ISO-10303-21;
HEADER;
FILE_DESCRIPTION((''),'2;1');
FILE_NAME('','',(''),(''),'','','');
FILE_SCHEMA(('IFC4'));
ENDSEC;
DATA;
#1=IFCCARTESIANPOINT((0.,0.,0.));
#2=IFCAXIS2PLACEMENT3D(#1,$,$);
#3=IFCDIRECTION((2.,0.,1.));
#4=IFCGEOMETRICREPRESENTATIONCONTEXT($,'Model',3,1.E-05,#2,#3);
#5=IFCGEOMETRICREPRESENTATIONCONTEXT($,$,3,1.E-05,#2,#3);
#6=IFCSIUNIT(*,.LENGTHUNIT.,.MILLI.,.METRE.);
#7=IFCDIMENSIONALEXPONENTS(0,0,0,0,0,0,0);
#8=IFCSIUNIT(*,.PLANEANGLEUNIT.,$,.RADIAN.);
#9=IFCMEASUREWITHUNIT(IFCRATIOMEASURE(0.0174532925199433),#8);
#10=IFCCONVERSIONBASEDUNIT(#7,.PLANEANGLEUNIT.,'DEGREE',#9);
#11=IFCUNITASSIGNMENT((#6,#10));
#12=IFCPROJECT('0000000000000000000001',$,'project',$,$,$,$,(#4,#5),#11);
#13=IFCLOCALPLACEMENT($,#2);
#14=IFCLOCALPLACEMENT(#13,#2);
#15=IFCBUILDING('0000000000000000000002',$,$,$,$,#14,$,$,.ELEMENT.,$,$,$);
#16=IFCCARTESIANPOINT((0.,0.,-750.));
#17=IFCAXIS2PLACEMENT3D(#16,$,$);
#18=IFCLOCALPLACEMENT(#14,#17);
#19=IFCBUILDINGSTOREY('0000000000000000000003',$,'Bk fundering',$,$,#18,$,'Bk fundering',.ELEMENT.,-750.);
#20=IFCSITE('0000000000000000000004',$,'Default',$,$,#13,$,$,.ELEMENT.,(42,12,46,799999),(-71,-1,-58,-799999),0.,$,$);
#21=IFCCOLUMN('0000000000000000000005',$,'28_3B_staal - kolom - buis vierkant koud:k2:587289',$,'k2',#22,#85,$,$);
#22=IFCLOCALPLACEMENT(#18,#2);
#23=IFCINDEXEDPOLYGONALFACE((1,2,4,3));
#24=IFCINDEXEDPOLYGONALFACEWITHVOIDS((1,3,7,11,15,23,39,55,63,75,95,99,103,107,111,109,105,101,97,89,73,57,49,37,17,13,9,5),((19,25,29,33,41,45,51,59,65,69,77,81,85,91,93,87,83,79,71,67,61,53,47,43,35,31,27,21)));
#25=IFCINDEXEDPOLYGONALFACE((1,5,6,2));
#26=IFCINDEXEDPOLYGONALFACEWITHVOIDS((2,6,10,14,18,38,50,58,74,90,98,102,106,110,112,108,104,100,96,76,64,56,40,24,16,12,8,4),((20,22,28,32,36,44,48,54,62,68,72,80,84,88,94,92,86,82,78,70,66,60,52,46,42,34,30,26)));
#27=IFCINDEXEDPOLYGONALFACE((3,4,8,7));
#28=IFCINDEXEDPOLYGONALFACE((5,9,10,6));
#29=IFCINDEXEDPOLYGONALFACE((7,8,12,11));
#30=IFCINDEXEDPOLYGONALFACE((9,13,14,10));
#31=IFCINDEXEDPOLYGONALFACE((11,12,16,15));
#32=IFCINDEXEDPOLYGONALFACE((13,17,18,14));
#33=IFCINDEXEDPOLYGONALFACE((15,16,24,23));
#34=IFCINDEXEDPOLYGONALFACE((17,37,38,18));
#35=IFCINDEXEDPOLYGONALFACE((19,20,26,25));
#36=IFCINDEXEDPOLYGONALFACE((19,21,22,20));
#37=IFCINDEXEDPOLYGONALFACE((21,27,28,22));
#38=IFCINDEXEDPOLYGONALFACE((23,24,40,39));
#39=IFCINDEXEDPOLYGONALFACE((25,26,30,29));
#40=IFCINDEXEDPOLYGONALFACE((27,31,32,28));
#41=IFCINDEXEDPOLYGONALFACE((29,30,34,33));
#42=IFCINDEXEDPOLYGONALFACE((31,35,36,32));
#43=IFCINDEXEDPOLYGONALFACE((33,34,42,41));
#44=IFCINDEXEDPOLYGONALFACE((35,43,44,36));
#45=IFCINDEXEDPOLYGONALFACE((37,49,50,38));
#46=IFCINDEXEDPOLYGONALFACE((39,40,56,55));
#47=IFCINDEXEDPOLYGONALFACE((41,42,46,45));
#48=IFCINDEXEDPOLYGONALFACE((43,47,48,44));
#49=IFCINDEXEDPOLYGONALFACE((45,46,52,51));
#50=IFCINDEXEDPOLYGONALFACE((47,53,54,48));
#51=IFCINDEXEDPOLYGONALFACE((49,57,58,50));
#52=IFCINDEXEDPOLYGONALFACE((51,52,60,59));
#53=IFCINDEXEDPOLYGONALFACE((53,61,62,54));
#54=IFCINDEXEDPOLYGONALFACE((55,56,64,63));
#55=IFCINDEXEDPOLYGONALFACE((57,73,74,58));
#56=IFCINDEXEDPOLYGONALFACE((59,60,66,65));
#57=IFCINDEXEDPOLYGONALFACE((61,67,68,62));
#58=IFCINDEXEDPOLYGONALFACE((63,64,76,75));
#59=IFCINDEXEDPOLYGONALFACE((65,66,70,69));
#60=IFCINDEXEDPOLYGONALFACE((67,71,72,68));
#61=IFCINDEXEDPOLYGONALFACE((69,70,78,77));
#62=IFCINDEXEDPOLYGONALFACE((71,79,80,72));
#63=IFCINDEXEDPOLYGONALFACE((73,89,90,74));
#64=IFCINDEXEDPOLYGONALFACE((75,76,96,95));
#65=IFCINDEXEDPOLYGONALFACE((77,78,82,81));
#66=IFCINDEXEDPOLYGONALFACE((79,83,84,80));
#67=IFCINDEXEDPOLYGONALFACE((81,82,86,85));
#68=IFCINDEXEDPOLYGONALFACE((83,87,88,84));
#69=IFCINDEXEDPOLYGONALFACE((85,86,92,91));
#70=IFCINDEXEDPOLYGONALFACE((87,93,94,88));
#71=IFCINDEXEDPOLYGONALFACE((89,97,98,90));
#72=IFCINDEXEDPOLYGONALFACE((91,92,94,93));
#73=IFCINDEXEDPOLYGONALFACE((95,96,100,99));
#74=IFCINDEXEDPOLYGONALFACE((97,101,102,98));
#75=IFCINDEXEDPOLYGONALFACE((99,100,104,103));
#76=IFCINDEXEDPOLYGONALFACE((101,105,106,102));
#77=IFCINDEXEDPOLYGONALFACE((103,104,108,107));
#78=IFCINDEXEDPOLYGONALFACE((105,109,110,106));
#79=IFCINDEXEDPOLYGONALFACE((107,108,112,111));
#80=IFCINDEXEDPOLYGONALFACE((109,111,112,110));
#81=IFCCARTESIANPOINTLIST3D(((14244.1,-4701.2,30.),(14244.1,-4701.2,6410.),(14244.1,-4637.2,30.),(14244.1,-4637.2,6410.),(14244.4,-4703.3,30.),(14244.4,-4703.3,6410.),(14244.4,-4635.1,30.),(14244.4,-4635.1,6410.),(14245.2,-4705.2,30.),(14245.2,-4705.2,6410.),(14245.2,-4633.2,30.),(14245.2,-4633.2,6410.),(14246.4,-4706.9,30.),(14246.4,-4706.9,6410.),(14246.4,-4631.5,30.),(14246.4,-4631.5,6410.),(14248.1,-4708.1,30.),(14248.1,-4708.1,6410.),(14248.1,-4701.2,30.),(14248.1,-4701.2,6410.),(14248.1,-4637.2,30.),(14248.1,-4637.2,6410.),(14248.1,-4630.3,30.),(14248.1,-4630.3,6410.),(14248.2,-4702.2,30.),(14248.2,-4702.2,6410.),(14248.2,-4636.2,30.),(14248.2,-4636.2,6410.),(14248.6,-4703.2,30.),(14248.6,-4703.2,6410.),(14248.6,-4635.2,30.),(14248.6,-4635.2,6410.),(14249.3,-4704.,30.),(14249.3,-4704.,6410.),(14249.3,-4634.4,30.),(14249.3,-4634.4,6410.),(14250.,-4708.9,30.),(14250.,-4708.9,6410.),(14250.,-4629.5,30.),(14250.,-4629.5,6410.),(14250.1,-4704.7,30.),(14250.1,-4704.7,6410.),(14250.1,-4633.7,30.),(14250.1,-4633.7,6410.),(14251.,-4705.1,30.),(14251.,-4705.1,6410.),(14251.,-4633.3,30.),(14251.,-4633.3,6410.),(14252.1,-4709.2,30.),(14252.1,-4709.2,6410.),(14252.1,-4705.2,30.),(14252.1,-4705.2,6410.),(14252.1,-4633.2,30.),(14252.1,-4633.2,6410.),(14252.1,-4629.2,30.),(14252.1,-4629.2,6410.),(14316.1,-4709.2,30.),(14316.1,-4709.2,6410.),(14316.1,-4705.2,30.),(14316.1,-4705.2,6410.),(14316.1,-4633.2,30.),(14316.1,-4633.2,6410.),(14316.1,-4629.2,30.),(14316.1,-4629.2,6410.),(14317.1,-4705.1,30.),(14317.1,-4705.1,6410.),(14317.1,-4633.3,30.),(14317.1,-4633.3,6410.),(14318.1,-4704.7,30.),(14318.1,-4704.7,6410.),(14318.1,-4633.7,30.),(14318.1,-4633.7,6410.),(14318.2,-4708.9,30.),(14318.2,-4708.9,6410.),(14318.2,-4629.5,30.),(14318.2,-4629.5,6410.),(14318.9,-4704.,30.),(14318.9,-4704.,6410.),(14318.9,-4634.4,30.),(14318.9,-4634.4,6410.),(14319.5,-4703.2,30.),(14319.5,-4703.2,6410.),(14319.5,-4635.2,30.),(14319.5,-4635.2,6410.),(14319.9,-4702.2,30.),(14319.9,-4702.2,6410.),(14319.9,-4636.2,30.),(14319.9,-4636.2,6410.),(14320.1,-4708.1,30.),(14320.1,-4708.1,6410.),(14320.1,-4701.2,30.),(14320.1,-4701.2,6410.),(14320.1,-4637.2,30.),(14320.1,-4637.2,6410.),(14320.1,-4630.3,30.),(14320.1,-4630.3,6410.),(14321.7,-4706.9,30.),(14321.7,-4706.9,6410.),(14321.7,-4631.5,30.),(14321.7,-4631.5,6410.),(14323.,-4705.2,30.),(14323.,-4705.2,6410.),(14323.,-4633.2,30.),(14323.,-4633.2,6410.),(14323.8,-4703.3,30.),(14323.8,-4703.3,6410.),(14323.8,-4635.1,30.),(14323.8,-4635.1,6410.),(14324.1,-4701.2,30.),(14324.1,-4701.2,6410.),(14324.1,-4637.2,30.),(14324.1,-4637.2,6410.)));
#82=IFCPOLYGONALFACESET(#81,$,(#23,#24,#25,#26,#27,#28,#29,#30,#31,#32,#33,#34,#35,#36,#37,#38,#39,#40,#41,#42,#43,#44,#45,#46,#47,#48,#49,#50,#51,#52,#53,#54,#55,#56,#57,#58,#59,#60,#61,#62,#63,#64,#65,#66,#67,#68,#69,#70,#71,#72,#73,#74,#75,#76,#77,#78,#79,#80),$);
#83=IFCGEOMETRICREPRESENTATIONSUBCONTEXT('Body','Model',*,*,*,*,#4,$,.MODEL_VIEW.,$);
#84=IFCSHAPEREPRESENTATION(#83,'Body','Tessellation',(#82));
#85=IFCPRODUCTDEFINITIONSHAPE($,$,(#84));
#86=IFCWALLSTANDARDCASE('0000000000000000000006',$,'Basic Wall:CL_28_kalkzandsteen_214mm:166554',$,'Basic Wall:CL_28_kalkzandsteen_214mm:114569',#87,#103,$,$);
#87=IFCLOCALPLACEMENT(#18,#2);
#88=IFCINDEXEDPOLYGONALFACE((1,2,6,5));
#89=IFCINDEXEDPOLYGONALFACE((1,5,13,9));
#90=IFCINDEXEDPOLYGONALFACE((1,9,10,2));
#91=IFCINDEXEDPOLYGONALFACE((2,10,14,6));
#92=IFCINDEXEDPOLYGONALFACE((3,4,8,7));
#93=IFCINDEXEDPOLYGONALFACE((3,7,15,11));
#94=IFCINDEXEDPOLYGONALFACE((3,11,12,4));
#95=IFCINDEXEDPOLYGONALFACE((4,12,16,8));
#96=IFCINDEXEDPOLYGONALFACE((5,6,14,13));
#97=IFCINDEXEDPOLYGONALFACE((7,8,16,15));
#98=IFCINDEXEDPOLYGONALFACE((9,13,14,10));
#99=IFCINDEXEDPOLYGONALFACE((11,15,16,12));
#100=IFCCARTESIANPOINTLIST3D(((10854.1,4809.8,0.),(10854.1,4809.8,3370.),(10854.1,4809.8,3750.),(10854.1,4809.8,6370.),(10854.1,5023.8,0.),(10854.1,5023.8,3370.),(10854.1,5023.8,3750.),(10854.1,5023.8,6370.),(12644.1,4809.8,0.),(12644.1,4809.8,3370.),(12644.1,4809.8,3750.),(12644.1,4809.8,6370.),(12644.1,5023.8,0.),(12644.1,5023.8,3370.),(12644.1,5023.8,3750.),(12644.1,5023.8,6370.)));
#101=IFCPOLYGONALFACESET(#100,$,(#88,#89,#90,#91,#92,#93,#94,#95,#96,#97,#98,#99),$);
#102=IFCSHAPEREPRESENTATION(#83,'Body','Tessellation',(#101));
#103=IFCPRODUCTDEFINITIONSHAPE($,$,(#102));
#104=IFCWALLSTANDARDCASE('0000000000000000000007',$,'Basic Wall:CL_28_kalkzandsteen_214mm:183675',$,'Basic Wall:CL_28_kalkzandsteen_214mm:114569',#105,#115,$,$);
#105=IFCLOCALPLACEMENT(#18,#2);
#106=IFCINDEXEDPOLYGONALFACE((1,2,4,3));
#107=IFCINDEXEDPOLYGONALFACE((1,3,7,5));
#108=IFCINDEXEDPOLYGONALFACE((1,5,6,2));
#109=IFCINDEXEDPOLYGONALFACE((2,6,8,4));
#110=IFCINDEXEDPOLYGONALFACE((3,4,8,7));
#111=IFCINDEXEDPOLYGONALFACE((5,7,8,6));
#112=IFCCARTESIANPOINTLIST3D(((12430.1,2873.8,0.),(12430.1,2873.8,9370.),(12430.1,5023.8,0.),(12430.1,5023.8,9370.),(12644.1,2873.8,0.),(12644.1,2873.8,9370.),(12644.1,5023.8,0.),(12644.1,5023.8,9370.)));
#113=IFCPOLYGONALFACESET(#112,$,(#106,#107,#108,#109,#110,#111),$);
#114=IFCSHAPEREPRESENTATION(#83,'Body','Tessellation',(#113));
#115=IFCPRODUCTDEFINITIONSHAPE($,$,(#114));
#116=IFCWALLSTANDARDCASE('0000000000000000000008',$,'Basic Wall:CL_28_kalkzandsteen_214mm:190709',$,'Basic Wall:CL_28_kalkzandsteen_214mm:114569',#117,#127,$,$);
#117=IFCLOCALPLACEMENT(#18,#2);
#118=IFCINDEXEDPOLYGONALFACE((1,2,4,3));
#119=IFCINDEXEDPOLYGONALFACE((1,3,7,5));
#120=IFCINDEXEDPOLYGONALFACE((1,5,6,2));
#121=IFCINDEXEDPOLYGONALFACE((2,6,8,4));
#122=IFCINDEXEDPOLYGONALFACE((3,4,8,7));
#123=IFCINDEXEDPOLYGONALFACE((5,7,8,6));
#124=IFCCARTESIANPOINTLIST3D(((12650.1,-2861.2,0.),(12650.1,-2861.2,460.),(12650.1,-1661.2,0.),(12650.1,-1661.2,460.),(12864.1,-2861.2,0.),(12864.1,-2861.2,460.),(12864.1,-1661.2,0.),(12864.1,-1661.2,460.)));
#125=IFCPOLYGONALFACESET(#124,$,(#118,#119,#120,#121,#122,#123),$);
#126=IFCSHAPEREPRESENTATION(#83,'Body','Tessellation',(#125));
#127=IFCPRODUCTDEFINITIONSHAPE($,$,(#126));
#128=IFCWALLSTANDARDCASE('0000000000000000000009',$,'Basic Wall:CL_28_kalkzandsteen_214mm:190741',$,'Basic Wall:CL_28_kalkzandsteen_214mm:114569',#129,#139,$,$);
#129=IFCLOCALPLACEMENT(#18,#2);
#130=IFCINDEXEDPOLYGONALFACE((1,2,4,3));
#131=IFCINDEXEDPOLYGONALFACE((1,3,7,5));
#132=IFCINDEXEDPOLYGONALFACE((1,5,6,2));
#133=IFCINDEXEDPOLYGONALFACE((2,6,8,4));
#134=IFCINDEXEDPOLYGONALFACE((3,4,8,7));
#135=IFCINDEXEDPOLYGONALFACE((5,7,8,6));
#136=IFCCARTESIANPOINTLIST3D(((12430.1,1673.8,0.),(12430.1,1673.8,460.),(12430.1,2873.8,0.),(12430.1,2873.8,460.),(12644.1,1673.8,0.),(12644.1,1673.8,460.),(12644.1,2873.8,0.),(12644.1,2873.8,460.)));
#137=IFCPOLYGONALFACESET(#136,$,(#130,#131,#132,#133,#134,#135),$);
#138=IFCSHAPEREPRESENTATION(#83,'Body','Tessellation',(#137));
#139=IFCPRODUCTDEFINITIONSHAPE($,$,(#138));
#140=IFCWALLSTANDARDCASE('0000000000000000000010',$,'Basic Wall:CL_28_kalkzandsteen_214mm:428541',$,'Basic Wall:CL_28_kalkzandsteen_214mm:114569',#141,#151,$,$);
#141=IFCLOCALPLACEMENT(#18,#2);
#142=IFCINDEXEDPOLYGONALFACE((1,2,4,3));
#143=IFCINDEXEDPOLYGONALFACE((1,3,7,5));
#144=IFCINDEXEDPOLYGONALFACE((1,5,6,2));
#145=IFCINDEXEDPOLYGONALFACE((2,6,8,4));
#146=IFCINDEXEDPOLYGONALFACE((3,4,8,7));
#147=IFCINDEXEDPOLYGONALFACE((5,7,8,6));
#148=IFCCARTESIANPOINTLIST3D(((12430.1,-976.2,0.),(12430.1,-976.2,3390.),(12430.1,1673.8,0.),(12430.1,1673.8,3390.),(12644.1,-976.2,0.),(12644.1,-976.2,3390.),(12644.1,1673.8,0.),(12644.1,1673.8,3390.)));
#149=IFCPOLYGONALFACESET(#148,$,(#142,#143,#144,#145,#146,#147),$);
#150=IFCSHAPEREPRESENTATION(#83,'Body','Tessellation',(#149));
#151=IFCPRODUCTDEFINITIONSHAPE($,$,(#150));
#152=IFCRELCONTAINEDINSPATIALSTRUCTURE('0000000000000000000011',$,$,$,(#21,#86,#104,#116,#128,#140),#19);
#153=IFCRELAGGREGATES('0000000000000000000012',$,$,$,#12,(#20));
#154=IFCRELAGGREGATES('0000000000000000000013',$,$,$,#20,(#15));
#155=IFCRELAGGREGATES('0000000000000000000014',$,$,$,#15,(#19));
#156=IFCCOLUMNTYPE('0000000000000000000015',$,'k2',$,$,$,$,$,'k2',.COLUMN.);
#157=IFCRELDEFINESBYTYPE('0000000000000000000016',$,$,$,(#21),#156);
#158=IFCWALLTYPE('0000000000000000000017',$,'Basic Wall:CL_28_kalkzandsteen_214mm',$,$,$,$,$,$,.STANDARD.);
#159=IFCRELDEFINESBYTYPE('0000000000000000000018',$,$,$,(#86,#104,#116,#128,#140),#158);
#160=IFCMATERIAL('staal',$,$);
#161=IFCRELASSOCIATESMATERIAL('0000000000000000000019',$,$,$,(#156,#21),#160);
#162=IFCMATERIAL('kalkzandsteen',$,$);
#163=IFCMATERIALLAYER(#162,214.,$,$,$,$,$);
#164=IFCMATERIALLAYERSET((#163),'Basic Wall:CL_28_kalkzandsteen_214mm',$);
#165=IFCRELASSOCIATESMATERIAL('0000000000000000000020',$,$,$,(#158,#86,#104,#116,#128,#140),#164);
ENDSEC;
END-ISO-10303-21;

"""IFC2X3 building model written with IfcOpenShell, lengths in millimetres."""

from ifc_helpers import new_model, entity, si_unit, converted_unit, direction, frame, frame_2d, origin, place, context, subcontext, project, spatial, polyline, circle_curve, parameter, trimmed, segment, composite_curve, rectangle, outline, extrude, clip, bounded_halfspace, source, transform, mapped, material, layer, layer_set, layer_usage, type_object, type_shapes, element, save


model = new_model("IFC2X3")

# Units and contexts
model_context = context("Model", 3, precision=1e-05, world=origin(), true_north=direction((2.0, 0.0, 1.0)))
context_of_model = context(None, 3, precision=1e-05, world=origin(), true_north=direction((2.0, 0.0, 1.0)))
body_context = subcontext(model_context, "Body", "Model", "MODEL_VIEW")
ifc_project = project(units=[si_unit("LENGTHUNIT", "METRE", prefix="MILLI"), converted_unit("PLANEANGLEUNIT", "DEGREE", entity("IfcRatioMeasure", 0.0174532925199433), si_unit("PLANEANGLEUNIT", "RADIAN"), dimensions=[0, 0, 0, 0, 0, 0, 0])], contexts=[model_context, context_of_model])

# Site, building, storey
site_placement = place(None, origin())
site = spatial("IfcSite", under=ifc_project, at=site_placement, Name="Default", CompositionType="ELEMENT", RefLatitude=(42, 12, 46, 799999), RefLongitude=(-71, -1, -58, -799999), RefElevation=0.0)
building_placement = place(site_placement, origin())
building = spatial("IfcBuilding", under=site, at=building_placement, CompositionType="ELEMENT")
storey_placement = place(building_placement, frame((0.0, 0.0, -750.0)))
storey = spatial("IfcBuildingStorey", under=building, at=storey_placement, Name="Bk fundering", LongName="Bk fundering", CompositionType="ELEMENT", Elevation=-750.0)

# Column
ifc_material_1 = material(Name="staal")
column_type = type_object("IfcColumnType", Name="k2", ElementType="k2", PredefinedType="COLUMN", material=ifc_material_1)
shared_shape = source(origin(), body_context, "Body", "SweptSolid", [
    extrude(outline(composite_curve([segment(polyline([(-32.0, -40.0), (32.0, -40.0)]), True, "CONTINUOUS"), segment(trimmed(circle_curve(frame_2d((32.0, -32.0), x_axis=(-1.0, 0.0)), 8.0), [parameter(90.0)], [parameter(180.0)], True, "PARAMETER"), True, "CONTINUOUS"), segment(polyline([(40.0, -32.0), (40.0, 32.0)]), True, "CONTINUOUS"), segment(trimmed(circle_curve(frame_2d((32.0, 32.0), x_axis=(-1.0, 0.0)), 8.0), [parameter(180.0)], [parameter(270.0)], True, "PARAMETER"), True, "CONTINUOUS"), segment(polyline([(32.0, 40.0), (-32.0, 40.0)]), True, "CONTINUOUS"), segment(trimmed(circle_curve(frame_2d((-32.0, 32.0), x_axis=(-1.0, 0.0)), 8.0), [parameter(270.0)], [parameter(360.0)], True, "PARAMETER"), True, "CONTINUOUS"), segment(polyline([(-40.0, 32.0), (-40.0, -32.0)]), True, "CONTINUOUS"), segment(trimmed(circle_curve(frame_2d((-32.0, -32.0), x_axis=(-1.0, 0.0)), 8.0), [parameter(360.0)], [parameter(90.0)], True, "PARAMETER"), True, "CONTINUOUS")], self_intersect=False), holes=[composite_curve([segment(trimmed(circle_curve(frame_2d((-32.0, -32.0), x_axis=(-1.0, 0.0)), 4.0), [parameter(0.0)], [parameter(90.0)], True, "PARAMETER"), False, "CONTINUOUS"), segment(polyline([(-36.0, -32.0), (-36.0, 32.0)]), True, "CONTINUOUS"), segment(trimmed(circle_curve(frame_2d((-32.0, 32.0), x_axis=(-1.0, 0.0)), 4.0), [parameter(270.0)], [parameter(0.0)], True, "PARAMETER"), False, "CONTINUOUS"), segment(polyline([(-32.0, 36.0), (32.0, 36.0)]), True, "CONTINUOUS"), segment(trimmed(circle_curve(frame_2d((32.0, 32.0), x_axis=(-1.0, 0.0)), 4.0), [parameter(180.0)], [parameter(270.0)], True, "PARAMETER"), False, "CONTINUOUS"), segment(polyline([(36.0, 32.0), (36.0, -32.0)]), True, "CONTINUOUS"), segment(trimmed(circle_curve(frame_2d((32.0, -32.0), x_axis=(-1.0, 0.0)), 4.0), [parameter(90.0)], [parameter(180.0)], True, "PARAMETER"), False, "CONTINUOUS"), segment(polyline([(32.0, -36.0), (-32.0, -36.0)]), True, "CONTINUOUS")], self_intersect=False)]), frame((14284.1, -4669.2, -720.0)), (0.0, 0.0, 1.0), 6380.0),
])
type_shapes(column_type, [shared_shape])
column_placement = place(storey_placement, frame((0.0, 0.0, 750.0)))
element("IfcColumn", 1, at=column_placement, inside=storey, type_object=column_type, material=ifc_material_1, Name="28_3B_staal - kolom - buis vierkant koud:k2:587289", ObjectType="k2", context=body_context, shape_type="MappedRepresentation", body=[
    mapped(shared_shape, transform((0.0, 0.0, 0.0), scale=1.0)),
])

# Wall, opening
ifc_material_2 = material(Name="kalkzandsteen")
ifc_layer_1 = layer(ifc_material_2, 214.0)
ifc_layer_set_1 = layer_set([ifc_layer_1], Name="Basic Wall:CL_28_kalkzandsteen_214mm")
ifc_layer_usage_1 = layer_usage(ifc_layer_set_1, "AXIS2", "NEGATIVE", 107.0)
wall_type_1 = type_object("IfcWallType", Name="Basic Wall:CL_28_kalkzandsteen_214mm", PredefinedType="STANDARD", material=ifc_layer_set_1)
wall_1_placement = place(storey_placement, frame((12644.1, 4916.8, 0.0), z_axis=(0.0, 0.0, 1.0), x_axis=(-1.0, 0.0, 0.0)))
wall_1 = element("IfcWallStandardCase", 2, at=wall_1_placement, inside=storey, type_object=wall_type_1, material=ifc_layer_usage_1, Name="Basic Wall:CL_28_kalkzandsteen_214mm:166554", ObjectType="Basic Wall:CL_28_kalkzandsteen_214mm:114569", context=body_context, shape_type="Clipping", body=[
    clip(extrude(rectangle(XDim=1790.0, YDim=214.0, at=frame_2d((895.0, 0.0), x_axis=(-1.0, 0.0))), origin(), (0.0, 0.0, 1.0), 6370.0), bounded_halfspace(frame((0.0, -107.0, 6370.0), z_axis=(0.0, 0.0, -1.0), x_axis=(-1.0, 0.0, 0.0)), True, frame((0.0, -107.0, 6370.0)), polyline([(0.0, 0.0), (1790.0, 0.0), (1790.0, 214.0), (0.0, 214.0), (0.0, 0.0)]))),
])
opening_placement = place(storey_placement, frame((12644.1, 4916.8, 0.0), z_axis=(0.0, 0.0, 1.0), x_axis=(-1.0, 0.0, 0.0)))
element("IfcOpeningElement", 3, at=opening_placement, cuts=wall_1, ObjectType="Opening", context=body_context, shape_type="SweptSolid", body=[
    extrude(rectangle(XDim=1790.0, YDim=214.0, at=frame_2d((0.0, 0.0), x_axis=(1.0, 0.0))), frame((895.0, 0.0, 3370.0)), (0.0, 0.0, 1.0), 380.0),
])

# Walls
ifc_layer_usage_2 = layer_usage(ifc_layer_set_1, "AXIS2", "NEGATIVE", 107.0)
wall_2_placement = place(storey_placement, frame((12537.1, 2873.8, 0.0), z_axis=(0.0, 0.0, 1.0), x_axis=(0.0, 1.0, 0.0)))
element("IfcWallStandardCase", 4, at=wall_2_placement, inside=storey, type_object=wall_type_1, material=ifc_layer_usage_2, Name="Basic Wall:CL_28_kalkzandsteen_214mm:183675", ObjectType="Basic Wall:CL_28_kalkzandsteen_214mm:114569", context=body_context, shape_type="Clipping", body=[
    clip(extrude(rectangle(XDim=2150.0, YDim=214.0, at=frame_2d((1075.0, 0.0), x_axis=(-1.0, 0.0))), origin(), (0.0, 0.0, 1.0), 9370.0), bounded_halfspace(frame((0.0, -107.0, 9370.0), z_axis=(0.0, 0.0, -1.0), x_axis=(0.0, -1.0, 0.0)), True, frame((0.0, -107.0, 9370.0)), polyline([(0.0, 0.0), (2150.0, 0.0), (2150.0, 214.0), (1936.0, 214.0), (0.0, 214.0), (0.0, 0.0)]))),
])
ifc_layer_usage_3 = layer_usage(ifc_layer_set_1, "AXIS2", "NEGATIVE", 107.0)
wall_3_placement = place(storey_placement, frame((12757.1, -2861.2, 0.0), z_axis=(0.0, 0.0, 1.0), x_axis=(0.0, 1.0, 0.0)))
element("IfcWallStandardCase", 5, at=wall_3_placement, inside=storey, type_object=wall_type_1, material=ifc_layer_usage_3, Name="Basic Wall:CL_28_kalkzandsteen_214mm:190709", ObjectType="Basic Wall:CL_28_kalkzandsteen_214mm:114569", context=body_context, shape_type="Clipping", body=[
    clip(extrude(rectangle(XDim=1200.0, YDim=214.0, at=frame_2d((600.0, 0.0), x_axis=(-1.0, 0.0))), origin(), (0.0, 0.0, 1.0), 460.0), bounded_halfspace(frame((0.0, -107.0, 460.0), z_axis=(0.0, 0.0, -1.0), x_axis=(-1.0, 0.0, 0.0)), True, frame((0.0, -107.0, 460.0)), polyline([(0.0, 0.0), (1200.0, 0.0), (1200.0, 214.0), (0.0, 214.0), (0.0, 0.0)]))),
])
ifc_layer_usage_4 = layer_usage(ifc_layer_set_1, "AXIS2", "NEGATIVE", 107.0)
wall_4_placement = place(storey_placement, frame((12537.1, 1673.8, 0.0), z_axis=(0.0, 0.0, 1.0), x_axis=(0.0, 1.0, 0.0)))
element("IfcWallStandardCase", 6, at=wall_4_placement, inside=storey, type_object=wall_type_1, material=ifc_layer_usage_4, Name="Basic Wall:CL_28_kalkzandsteen_214mm:190741", ObjectType="Basic Wall:CL_28_kalkzandsteen_214mm:114569", context=body_context, shape_type="Clipping", body=[
    clip(extrude(rectangle(XDim=1200.0, YDim=214.0, at=frame_2d((600.0, 0.0), x_axis=(-1.0, 0.0))), origin(), (0.0, 0.0, 1.0), 460.0), bounded_halfspace(frame((0.0, -107.0, 460.0), z_axis=(0.0, 0.0, -1.0), x_axis=(-1.0, 0.0, 0.0)), True, frame((0.0, -107.0, 460.0)), polyline([(0.0, 0.0), (1200.0, 0.0), (1200.0, 214.0), (0.0, 214.0), (0.0, 0.0)]))),
])
ifc_layer_usage_5 = layer_usage(ifc_layer_set_1, "AXIS2", "NEGATIVE", 107.0)
wall_5_placement = place(storey_placement, frame((12537.1, -976.2, 0.0), z_axis=(0.0, 0.0, 1.0), x_axis=(0.0, 1.0, 0.0)))
element("IfcWallStandardCase", 7, at=wall_5_placement, inside=storey, type_object=wall_type_1, material=ifc_layer_usage_5, Name="Basic Wall:CL_28_kalkzandsteen_214mm:428541", ObjectType="Basic Wall:CL_28_kalkzandsteen_214mm:114569", context=body_context, shape_type="SweptSolid", body=[
    extrude(rectangle(XDim=2650.0, YDim=214.0, at=frame_2d((1325.0, 0.0), x_axis=(-1.0, 0.0))), origin(), (0.0, 0.0, 1.0), 3390.0),
])

save(model, "model.ifc")
